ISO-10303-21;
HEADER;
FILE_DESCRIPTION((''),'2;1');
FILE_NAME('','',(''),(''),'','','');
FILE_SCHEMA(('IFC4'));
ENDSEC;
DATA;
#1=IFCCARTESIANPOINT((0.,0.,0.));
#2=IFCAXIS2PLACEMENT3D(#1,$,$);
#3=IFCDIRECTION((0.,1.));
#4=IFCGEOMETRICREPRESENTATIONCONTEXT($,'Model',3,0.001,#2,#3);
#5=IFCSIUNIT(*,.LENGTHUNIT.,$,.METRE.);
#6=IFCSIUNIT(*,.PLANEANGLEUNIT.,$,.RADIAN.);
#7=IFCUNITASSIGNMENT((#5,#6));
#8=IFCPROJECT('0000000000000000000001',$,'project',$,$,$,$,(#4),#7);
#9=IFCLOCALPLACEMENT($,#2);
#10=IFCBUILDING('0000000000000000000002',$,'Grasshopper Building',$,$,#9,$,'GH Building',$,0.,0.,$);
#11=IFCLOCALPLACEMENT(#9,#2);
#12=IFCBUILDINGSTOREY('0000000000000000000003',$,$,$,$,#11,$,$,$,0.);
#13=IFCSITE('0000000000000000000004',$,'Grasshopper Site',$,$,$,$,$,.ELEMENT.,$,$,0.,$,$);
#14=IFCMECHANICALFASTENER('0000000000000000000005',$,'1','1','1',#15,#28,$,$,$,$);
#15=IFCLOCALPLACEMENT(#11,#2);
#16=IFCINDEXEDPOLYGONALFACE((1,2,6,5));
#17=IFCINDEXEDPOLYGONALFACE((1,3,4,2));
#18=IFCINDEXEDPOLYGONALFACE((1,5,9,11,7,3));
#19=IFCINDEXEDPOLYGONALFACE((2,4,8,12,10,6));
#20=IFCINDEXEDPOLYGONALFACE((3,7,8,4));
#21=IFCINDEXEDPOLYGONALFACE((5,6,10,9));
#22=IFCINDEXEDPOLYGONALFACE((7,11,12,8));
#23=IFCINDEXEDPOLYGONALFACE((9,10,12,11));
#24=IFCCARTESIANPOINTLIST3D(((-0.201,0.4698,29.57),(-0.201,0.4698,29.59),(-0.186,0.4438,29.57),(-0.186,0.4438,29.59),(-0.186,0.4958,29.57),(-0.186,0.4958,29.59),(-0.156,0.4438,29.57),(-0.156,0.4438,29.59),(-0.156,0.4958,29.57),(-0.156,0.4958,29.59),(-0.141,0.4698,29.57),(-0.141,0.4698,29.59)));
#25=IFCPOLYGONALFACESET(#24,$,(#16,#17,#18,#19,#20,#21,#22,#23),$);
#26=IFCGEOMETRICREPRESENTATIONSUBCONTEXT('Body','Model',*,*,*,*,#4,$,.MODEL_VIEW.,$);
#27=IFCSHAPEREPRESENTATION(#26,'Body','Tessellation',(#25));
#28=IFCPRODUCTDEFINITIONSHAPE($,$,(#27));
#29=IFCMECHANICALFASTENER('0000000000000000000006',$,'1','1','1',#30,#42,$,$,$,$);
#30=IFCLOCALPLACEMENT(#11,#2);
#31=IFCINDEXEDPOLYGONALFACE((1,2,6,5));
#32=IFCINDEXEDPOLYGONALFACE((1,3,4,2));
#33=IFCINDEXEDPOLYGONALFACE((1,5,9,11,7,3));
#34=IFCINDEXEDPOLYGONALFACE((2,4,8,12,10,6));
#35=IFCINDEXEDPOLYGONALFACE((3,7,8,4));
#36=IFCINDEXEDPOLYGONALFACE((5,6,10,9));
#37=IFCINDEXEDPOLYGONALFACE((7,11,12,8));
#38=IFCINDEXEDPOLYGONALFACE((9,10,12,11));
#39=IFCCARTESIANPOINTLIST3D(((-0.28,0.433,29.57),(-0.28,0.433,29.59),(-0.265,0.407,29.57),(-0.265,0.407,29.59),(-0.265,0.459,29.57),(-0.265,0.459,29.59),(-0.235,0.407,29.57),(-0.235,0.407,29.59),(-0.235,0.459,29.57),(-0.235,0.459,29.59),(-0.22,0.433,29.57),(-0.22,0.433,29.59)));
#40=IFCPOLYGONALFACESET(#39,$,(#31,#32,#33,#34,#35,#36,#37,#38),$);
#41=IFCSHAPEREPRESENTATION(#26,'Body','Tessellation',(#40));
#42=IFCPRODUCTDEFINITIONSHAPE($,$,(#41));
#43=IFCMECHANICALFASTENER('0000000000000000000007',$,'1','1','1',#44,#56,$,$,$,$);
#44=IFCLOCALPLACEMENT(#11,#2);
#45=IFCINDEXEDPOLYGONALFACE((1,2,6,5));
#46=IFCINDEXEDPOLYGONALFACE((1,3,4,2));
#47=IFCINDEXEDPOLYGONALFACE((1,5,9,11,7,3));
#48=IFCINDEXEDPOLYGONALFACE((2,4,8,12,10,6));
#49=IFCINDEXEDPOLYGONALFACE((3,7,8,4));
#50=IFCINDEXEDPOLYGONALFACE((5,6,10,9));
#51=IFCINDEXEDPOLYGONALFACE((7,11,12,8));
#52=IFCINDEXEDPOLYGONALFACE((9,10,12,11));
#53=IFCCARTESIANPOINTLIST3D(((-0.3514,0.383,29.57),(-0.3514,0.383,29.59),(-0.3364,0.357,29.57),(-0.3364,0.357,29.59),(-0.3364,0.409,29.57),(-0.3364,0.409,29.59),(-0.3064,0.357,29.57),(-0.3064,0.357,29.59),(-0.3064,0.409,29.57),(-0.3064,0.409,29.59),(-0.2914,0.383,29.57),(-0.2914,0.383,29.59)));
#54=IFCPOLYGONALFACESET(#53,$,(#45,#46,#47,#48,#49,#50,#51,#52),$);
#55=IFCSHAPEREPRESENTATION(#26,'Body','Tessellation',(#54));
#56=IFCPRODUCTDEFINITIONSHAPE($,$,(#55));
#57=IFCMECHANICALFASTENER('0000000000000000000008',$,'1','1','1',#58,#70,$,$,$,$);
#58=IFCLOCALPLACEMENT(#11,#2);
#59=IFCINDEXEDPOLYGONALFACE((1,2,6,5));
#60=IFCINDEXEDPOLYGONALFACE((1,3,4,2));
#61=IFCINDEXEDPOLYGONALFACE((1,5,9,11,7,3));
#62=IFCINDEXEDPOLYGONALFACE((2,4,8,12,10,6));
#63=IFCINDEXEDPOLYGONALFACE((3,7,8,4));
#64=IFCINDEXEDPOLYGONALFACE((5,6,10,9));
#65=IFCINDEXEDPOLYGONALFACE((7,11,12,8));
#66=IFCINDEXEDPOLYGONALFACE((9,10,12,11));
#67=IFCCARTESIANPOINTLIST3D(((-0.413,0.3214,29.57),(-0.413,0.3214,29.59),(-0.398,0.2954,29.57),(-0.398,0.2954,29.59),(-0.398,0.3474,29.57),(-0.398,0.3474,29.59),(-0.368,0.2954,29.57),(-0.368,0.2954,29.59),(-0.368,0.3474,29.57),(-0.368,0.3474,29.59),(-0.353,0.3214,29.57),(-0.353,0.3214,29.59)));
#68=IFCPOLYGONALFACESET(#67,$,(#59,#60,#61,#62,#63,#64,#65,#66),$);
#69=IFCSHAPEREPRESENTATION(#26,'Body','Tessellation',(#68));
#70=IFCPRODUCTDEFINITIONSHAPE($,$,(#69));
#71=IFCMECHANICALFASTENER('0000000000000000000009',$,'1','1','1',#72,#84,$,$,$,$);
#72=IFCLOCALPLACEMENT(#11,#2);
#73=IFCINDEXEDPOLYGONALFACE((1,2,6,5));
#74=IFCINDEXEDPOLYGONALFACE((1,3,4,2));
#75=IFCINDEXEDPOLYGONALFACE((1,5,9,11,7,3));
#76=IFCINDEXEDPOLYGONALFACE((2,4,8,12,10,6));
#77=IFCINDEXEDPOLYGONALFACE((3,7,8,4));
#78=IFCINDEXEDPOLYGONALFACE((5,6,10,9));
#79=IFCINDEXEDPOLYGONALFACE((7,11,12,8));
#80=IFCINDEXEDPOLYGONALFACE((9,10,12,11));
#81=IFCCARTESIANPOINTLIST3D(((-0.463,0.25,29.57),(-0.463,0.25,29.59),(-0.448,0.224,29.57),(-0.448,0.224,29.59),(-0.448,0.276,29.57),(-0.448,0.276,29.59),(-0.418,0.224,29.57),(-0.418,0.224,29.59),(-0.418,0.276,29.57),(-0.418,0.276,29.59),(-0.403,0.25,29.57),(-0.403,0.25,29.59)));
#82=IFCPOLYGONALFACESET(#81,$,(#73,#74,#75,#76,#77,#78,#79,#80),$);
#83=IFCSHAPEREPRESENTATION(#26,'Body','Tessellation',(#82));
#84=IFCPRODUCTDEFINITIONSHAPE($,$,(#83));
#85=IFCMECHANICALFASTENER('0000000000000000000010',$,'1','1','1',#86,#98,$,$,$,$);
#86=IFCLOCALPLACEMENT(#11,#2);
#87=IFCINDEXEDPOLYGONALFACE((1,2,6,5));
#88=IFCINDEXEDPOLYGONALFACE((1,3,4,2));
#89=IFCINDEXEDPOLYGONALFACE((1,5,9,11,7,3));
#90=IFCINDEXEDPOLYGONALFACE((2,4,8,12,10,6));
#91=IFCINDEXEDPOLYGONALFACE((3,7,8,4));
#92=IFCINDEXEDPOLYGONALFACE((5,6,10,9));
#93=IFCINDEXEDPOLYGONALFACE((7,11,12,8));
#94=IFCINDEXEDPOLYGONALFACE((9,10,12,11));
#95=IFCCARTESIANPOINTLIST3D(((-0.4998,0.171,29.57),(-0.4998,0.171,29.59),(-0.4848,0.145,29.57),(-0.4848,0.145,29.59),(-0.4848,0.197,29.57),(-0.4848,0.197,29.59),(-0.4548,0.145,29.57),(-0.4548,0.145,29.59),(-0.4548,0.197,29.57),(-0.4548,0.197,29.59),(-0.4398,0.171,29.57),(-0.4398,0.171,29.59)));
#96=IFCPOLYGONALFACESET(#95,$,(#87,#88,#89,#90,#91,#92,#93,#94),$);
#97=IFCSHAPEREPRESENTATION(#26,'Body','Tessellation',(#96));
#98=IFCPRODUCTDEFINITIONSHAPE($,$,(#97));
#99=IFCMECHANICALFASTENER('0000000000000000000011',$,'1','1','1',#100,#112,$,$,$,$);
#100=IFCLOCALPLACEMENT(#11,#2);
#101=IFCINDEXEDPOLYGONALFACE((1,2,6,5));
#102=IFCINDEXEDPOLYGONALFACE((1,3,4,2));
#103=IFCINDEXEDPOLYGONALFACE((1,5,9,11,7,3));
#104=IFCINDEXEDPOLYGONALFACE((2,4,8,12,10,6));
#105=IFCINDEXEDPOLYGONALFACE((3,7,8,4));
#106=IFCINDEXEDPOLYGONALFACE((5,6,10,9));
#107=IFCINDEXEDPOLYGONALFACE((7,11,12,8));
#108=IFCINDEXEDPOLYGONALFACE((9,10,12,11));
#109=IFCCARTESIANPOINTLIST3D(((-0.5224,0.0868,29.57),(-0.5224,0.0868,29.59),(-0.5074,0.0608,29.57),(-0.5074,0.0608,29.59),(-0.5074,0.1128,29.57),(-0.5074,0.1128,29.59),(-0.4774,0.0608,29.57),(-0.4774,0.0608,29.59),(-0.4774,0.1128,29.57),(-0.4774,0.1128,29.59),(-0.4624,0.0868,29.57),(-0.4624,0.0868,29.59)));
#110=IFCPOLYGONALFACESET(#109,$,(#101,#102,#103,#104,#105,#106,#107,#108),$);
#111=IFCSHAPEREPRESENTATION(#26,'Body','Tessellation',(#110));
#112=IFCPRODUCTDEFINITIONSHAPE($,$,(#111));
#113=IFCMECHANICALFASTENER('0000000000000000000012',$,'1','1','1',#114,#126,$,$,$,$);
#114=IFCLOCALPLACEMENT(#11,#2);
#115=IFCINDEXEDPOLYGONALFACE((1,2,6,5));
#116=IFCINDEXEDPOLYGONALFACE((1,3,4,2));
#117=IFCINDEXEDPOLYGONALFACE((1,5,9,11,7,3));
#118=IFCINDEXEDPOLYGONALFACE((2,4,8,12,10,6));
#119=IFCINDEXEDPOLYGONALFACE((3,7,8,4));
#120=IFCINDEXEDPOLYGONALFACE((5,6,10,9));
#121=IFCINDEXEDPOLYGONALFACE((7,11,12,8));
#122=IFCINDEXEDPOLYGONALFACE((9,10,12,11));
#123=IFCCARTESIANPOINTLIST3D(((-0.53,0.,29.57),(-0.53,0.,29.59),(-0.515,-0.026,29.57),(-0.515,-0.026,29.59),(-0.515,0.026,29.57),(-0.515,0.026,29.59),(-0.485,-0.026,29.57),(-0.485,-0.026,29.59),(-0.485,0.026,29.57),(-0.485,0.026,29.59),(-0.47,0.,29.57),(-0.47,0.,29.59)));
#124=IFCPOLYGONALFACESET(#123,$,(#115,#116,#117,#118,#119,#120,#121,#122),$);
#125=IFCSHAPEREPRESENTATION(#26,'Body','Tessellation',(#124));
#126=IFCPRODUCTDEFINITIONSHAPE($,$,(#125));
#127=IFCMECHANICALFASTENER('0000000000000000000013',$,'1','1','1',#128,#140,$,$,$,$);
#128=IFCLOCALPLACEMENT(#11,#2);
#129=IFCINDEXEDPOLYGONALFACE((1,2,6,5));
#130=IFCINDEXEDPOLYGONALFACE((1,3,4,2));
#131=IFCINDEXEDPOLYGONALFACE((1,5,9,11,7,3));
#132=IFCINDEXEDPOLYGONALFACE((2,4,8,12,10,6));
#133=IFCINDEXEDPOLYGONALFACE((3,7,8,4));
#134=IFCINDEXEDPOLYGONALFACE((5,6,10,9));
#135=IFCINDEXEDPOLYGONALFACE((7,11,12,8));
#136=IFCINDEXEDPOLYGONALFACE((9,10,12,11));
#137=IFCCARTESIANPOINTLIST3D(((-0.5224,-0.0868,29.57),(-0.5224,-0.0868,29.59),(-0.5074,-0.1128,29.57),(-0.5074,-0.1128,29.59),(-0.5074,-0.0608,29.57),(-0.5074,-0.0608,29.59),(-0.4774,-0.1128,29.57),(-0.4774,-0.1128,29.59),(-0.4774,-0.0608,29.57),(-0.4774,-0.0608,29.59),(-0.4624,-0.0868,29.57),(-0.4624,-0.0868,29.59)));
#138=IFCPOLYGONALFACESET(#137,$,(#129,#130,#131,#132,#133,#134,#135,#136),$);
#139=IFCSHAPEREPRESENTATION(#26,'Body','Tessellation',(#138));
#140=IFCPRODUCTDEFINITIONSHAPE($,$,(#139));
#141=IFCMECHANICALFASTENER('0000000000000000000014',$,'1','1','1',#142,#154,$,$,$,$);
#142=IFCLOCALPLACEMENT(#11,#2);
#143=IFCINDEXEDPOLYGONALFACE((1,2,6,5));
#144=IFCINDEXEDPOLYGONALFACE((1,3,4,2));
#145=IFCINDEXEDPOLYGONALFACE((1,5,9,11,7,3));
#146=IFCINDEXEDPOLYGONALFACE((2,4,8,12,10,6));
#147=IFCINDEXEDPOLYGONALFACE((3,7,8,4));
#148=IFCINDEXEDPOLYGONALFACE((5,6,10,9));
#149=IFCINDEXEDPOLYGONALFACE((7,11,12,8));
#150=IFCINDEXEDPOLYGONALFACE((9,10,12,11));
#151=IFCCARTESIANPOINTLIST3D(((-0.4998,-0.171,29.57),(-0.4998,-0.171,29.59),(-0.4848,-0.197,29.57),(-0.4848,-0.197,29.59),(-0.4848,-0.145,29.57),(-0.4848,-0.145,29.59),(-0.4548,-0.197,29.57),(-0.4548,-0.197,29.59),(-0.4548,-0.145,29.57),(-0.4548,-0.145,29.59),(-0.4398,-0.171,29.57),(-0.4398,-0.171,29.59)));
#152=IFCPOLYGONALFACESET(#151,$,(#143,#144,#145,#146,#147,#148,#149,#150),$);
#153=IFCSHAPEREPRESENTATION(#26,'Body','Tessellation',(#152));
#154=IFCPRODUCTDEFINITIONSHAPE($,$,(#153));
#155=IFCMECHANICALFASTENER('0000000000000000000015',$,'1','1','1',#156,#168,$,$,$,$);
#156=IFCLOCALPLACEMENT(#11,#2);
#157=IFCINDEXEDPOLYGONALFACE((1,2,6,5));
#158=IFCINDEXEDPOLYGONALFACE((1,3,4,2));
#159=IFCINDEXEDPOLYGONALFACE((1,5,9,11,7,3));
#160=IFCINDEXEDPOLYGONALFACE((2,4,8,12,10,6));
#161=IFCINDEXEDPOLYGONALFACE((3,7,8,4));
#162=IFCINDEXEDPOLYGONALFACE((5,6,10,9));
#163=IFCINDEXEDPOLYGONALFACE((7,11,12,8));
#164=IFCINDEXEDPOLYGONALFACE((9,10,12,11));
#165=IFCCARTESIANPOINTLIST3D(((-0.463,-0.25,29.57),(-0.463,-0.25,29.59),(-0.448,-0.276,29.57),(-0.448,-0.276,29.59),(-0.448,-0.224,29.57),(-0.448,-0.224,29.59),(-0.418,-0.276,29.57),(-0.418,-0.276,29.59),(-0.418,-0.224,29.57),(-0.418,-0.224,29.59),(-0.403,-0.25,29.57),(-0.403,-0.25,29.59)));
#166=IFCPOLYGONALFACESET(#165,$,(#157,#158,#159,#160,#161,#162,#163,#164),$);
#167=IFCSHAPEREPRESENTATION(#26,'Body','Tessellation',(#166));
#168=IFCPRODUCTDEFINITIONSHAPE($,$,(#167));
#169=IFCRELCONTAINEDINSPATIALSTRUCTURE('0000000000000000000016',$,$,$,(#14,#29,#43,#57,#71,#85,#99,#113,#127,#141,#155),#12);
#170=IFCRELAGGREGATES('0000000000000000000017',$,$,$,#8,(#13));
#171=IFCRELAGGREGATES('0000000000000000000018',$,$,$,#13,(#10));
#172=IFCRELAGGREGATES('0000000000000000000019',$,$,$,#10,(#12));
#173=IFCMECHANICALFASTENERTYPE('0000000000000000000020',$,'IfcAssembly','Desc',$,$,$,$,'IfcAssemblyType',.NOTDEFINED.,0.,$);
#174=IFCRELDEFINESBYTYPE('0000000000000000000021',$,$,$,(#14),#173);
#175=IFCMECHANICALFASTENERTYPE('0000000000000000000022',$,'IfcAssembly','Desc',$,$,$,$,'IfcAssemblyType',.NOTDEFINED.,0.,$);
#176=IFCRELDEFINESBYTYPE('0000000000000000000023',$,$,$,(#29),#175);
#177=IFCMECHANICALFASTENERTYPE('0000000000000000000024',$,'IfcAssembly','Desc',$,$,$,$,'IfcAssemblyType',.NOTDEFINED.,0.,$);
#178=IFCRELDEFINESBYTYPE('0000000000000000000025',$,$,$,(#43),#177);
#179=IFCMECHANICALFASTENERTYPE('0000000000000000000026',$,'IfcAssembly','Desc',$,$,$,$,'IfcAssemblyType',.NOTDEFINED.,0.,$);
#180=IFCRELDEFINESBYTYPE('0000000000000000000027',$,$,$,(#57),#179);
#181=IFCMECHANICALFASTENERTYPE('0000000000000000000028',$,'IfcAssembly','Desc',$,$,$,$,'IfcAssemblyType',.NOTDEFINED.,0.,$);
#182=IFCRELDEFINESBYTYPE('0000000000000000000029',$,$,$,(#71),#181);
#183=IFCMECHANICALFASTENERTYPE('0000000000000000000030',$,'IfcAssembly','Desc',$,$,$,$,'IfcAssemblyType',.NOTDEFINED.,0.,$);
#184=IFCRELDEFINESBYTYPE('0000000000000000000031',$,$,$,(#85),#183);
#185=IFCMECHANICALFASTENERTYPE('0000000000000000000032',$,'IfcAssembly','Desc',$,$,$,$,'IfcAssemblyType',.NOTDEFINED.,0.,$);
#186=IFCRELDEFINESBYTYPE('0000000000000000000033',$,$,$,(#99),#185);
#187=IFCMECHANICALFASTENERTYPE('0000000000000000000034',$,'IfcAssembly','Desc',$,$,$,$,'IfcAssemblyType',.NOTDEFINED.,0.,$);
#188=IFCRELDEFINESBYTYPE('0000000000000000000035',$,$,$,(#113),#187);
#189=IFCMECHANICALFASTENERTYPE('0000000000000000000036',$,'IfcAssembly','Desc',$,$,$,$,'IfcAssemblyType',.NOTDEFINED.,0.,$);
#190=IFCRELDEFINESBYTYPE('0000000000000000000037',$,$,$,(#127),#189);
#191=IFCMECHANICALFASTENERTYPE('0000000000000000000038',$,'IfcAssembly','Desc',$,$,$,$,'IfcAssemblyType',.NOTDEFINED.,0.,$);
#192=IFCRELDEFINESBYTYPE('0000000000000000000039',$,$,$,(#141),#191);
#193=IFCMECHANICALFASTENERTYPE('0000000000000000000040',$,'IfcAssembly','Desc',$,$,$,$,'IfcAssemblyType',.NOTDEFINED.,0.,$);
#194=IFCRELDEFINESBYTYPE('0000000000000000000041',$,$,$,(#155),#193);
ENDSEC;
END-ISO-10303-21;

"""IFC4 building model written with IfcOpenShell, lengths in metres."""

from ifc_helpers import new_model, si_unit, direction, frame, origin, place, context, subcontext, project, spatial, indexed_curve, outline, extrude, source, transform, mapped, type_object, type_shapes, element, save


model = new_model("IFC4")

# Units and contexts
model_context = context("Model", 3, precision=0.001, world=origin(), true_north=direction((0.0, 1.0)))
body_context = subcontext(model_context, "Body", "Model", "MODEL_VIEW")
ifc_project = project(units=[si_unit("LENGTHUNIT", "METRE"), si_unit("PLANEANGLEUNIT", "RADIAN")], contexts=[model_context])

# Site, building, storey
site = spatial("IfcSite", under=ifc_project, Name="Grasshopper Site", CompositionType="ELEMENT", RefElevation=0.0)
building_placement = place(None, origin())
building = spatial("IfcBuilding", under=site, at=building_placement, Name="Grasshopper Building", LongName="GH Building", ElevationOfRefHeight=0.0, ElevationOfTerrain=0.0)
storey_placement = place(building_placement, origin())
storey = spatial("IfcBuildingStorey", under=building, at=storey_placement, Elevation=0.0)

# Mechanical fasteners
mechanical_fastener_type_1 = type_object("IfcMechanicalFastenerType", Name="IfcAssembly", Description="Desc", ElementType="IfcAssemblyType", NominalDiameter=0.0)
shared_shape_1 = source(origin(), body_context, "Body", "SweptSolid", [
    extrude(outline(indexed_curve([(0.03, 0.0), (0.015, 0.026), (-0.015, 0.026), (-0.03, 0.0), (-0.015, -0.026), (0.015, -0.026), (0.03, 0.0)])), frame((-0.171, 0.4698, 29.57)), (0.0, 0.0, 1.0), 0.02),
])
type_shapes(mechanical_fastener_type_1, [shared_shape_1])
mechanical_fastener_1_placement = place(storey_placement, origin())
element("IfcMechanicalFastener", 1, at=mechanical_fastener_1_placement, inside=storey, type_object=mechanical_fastener_type_1, Name="1", Description="1", ObjectType="1", context=body_context, shape_type="MappedRepresentation", body=[
    mapped(shared_shape_1, transform((0.0, 0.0, 0.0), scale=1.0)),
])
mechanical_fastener_type_2 = type_object("IfcMechanicalFastenerType", Name="IfcAssembly", Description="Desc", ElementType="IfcAssemblyType", NominalDiameter=0.0)
shared_shape_2 = source(origin(), body_context, "Body", "SweptSolid", [
    extrude(outline(indexed_curve([(0.03, 0.0), (0.015, 0.026), (-0.015, 0.026), (-0.03, 0.0), (-0.015, -0.026), (0.015, -0.026), (0.03, 0.0)])), frame((-0.25, 0.433, 29.57)), (0.0, 0.0, 1.0), 0.02),
])
type_shapes(mechanical_fastener_type_2, [shared_shape_2])
mechanical_fastener_2_placement = place(storey_placement, origin())
element("IfcMechanicalFastener", 2, at=mechanical_fastener_2_placement, inside=storey, type_object=mechanical_fastener_type_2, Name="1", Description="1", ObjectType="1", context=body_context, shape_type="MappedRepresentation", body=[
    mapped(shared_shape_2, transform((0.0, 0.0, 0.0), scale=1.0)),
])
mechanical_fastener_type_3 = type_object("IfcMechanicalFastenerType", Name="IfcAssembly", Description="Desc", ElementType="IfcAssemblyType", NominalDiameter=0.0)
shared_shape_3 = source(origin(), body_context, "Body", "SweptSolid", [
    extrude(outline(indexed_curve([(0.03, 0.0), (0.015, 0.026), (-0.015, 0.026), (-0.03, 0.0), (-0.015, -0.026), (0.015, -0.026), (0.03, 0.0)])), frame((-0.3214, 0.383, 29.57)), (0.0, 0.0, 1.0), 0.02),
])
type_shapes(mechanical_fastener_type_3, [shared_shape_3])
mechanical_fastener_3_placement = place(storey_placement, origin())
element("IfcMechanicalFastener", 3, at=mechanical_fastener_3_placement, inside=storey, type_object=mechanical_fastener_type_3, Name="1", Description="1", ObjectType="1", context=body_context, shape_type="MappedRepresentation", body=[
    mapped(shared_shape_3, transform((0.0, 0.0, 0.0), scale=1.0)),
])
mechanical_fastener_type_4 = type_object("IfcMechanicalFastenerType", Name="IfcAssembly", Description="Desc", ElementType="IfcAssemblyType", NominalDiameter=0.0)
shared_shape_4 = source(origin(), body_context, "Body", "SweptSolid", [
    extrude(outline(indexed_curve([(0.03, 0.0), (0.015, 0.026), (-0.015, 0.026), (-0.03, 0.0), (-0.015, -0.026), (0.015, -0.026), (0.03, 0.0)])), frame((-0.383, 0.3214, 29.57)), (0.0, 0.0, 1.0), 0.02),
])
type_shapes(mechanical_fastener_type_4, [shared_shape_4])
mechanical_fastener_4_placement = place(storey_placement, origin())
element("IfcMechanicalFastener", 4, at=mechanical_fastener_4_placement, inside=storey, type_object=mechanical_fastener_type_4, Name="1", Description="1", ObjectType="1", context=body_context, shape_type="MappedRepresentation", body=[
    mapped(shared_shape_4, transform((0.0, 0.0, 0.0), scale=1.0)),
])
mechanical_fastener_type_5 = type_object("IfcMechanicalFastenerType", Name="IfcAssembly", Description="Desc", ElementType="IfcAssemblyType", NominalDiameter=0.0)
shared_shape_5 = source(origin(), body_context, "Body", "SweptSolid", [
    extrude(outline(indexed_curve([(0.03, 0.0), (0.015, 0.026), (-0.015, 0.026), (-0.03, 0.0), (-0.015, -0.026), (0.015, -0.026), (0.03, 0.0)])), frame((-0.433, 0.25, 29.57)), (0.0, 0.0, 1.0), 0.02),
])
type_shapes(mechanical_fastener_type_5, [shared_shape_5])
mechanical_fastener_5_placement = place(storey_placement, origin())
element("IfcMechanicalFastener", 5, at=mechanical_fastener_5_placement, inside=storey, type_object=mechanical_fastener_type_5, Name="1", Description="1", ObjectType="1", context=body_context, shape_type="MappedRepresentation", body=[
    mapped(shared_shape_5, transform((0.0, 0.0, 0.0), scale=1.0)),
])
mechanical_fastener_type_6 = type_object("IfcMechanicalFastenerType", Name="IfcAssembly", Description="Desc", ElementType="IfcAssemblyType", NominalDiameter=0.0)
shared_shape_6 = source(origin(), body_context, "Body", "SweptSolid", [
    extrude(outline(indexed_curve([(0.03, 0.0), (0.015, 0.026), (-0.015, 0.026), (-0.03, 0.0), (-0.015, -0.026), (0.015, -0.026), (0.03, 0.0)])), frame((-0.4698, 0.171, 29.57)), (0.0, 0.0, 1.0), 0.02),
])
type_shapes(mechanical_fastener_type_6, [shared_shape_6])
mechanical_fastener_6_placement = place(storey_placement, origin())
element("IfcMechanicalFastener", 6, at=mechanical_fastener_6_placement, inside=storey, type_object=mechanical_fastener_type_6, Name="1", Description="1", ObjectType="1", context=body_context, shape_type="MappedRepresentation", body=[
    mapped(shared_shape_6, transform((0.0, 0.0, 0.0), scale=1.0)),
])
mechanical_fastener_type_7 = type_object("IfcMechanicalFastenerType", Name="IfcAssembly", Description="Desc", ElementType="IfcAssemblyType", NominalDiameter=0.0)
shared_shape_7 = source(origin(), body_context, "Body", "SweptSolid", [
    extrude(outline(indexed_curve([(0.03, 0.0), (0.015, 0.026), (-0.015, 0.026), (-0.03, 0.0), (-0.015, -0.026), (0.015, -0.026), (0.03, 0.0)])), frame((-0.4924, 0.0868, 29.57)), (0.0, 0.0, 1.0), 0.02),
])
type_shapes(mechanical_fastener_type_7, [shared_shape_7])
mechanical_fastener_7_placement = place(storey_placement, origin())
element("IfcMechanicalFastener", 7, at=mechanical_fastener_7_placement, inside=storey, type_object=mechanical_fastener_type_7, Name="1", Description="1", ObjectType="1", context=body_context, shape_type="MappedRepresentation", body=[
    mapped(shared_shape_7, transform((0.0, 0.0, 0.0), scale=1.0)),
])
mechanical_fastener_type_8 = type_object("IfcMechanicalFastenerType", Name="IfcAssembly", Description="Desc", ElementType="IfcAssemblyType", NominalDiameter=0.0)
shared_shape_8 = source(origin(), body_context, "Body", "SweptSolid", [
    extrude(outline(indexed_curve([(0.03, 0.0), (0.015, 0.026), (-0.015, 0.026), (-0.03, 0.0), (-0.015, -0.026), (0.015, -0.026), (0.03, 0.0)])), frame((-0.5, 0.0, 29.57)), (0.0, 0.0, 1.0), 0.02),
])
type_shapes(mechanical_fastener_type_8, [shared_shape_8])
mechanical_fastener_8_placement = place(storey_placement, origin())
element("IfcMechanicalFastener", 8, at=mechanical_fastener_8_placement, inside=storey, type_object=mechanical_fastener_type_8, Name="1", Description="1", ObjectType="1", context=body_context, shape_type="MappedRepresentation", body=[
    mapped(shared_shape_8, transform((0.0, 0.0, 0.0), scale=1.0)),
])
mechanical_fastener_type_9 = type_object("IfcMechanicalFastenerType", Name="IfcAssembly", Description="Desc", ElementType="IfcAssemblyType", NominalDiameter=0.0)
shared_shape_9 = source(origin(), body_context, "Body", "SweptSolid", [
    extrude(outline(indexed_curve([(0.03, 0.0), (0.015, 0.026), (-0.015, 0.026), (-0.03, 0.0), (-0.015, -0.026), (0.015, -0.026), (0.03, 0.0)])), frame((-0.4924, -0.0868, 29.57)), (0.0, 0.0, 1.0), 0.02),
])
type_shapes(mechanical_fastener_type_9, [shared_shape_9])
mechanical_fastener_9_placement = place(storey_placement, origin())
element("IfcMechanicalFastener", 9, at=mechanical_fastener_9_placement, inside=storey, type_object=mechanical_fastener_type_9, Name="1", Description="1", ObjectType="1", context=body_context, shape_type="MappedRepresentation", body=[
    mapped(shared_shape_9, transform((0.0, 0.0, 0.0), scale=1.0)),
])
mechanical_fastener_type_10 = type_object("IfcMechanicalFastenerType", Name="IfcAssembly", Description="Desc", ElementType="IfcAssemblyType", NominalDiameter=0.0)
shared_shape_10 = source(origin(), body_context, "Body", "SweptSolid", [
    extrude(outline(indexed_curve([(0.03, 0.0), (0.015, 0.026), (-0.015, 0.026), (-0.03, 0.0), (-0.015, -0.026), (0.015, -0.026), (0.03, 0.0)])), frame((-0.4698, -0.171, 29.57)), (0.0, 0.0, 1.0), 0.02),
])
type_shapes(mechanical_fastener_type_10, [shared_shape_10])
mechanical_fastener_10_placement = place(storey_placement, origin())
element("IfcMechanicalFastener", 10, at=mechanical_fastener_10_placement, inside=storey, type_object=mechanical_fastener_type_10, Name="1", Description="1", ObjectType="1", context=body_context, shape_type="MappedRepresentation", body=[
    mapped(shared_shape_10, transform((0.0, 0.0, 0.0), scale=1.0)),
])
mechanical_fastener_type_11 = type_object("IfcMechanicalFastenerType", Name="IfcAssembly", Description="Desc", ElementType="IfcAssemblyType", NominalDiameter=0.0)
shared_shape_11 = source(origin(), body_context, "Body", "SweptSolid", [
    extrude(outline(indexed_curve([(0.03, 0.0), (0.015, 0.026), (-0.015, 0.026), (-0.03, 0.0), (-0.015, -0.026), (0.015, -0.026), (0.03, 0.0)])), frame((-0.433, -0.25, 29.57)), (0.0, 0.0, 1.0), 0.02),
])
type_shapes(mechanical_fastener_type_11, [shared_shape_11])
mechanical_fastener_11_placement = place(storey_placement, origin())
element("IfcMechanicalFastener", 11, at=mechanical_fastener_11_placement, inside=storey, type_object=mechanical_fastener_type_11, Name="1", Description="1", ObjectType="1", context=body_context, shape_type="MappedRepresentation", body=[
    mapped(shared_shape_11, transform((0.0, 0.0, 0.0), scale=1.0)),
])

save(model, "model.ifc")
